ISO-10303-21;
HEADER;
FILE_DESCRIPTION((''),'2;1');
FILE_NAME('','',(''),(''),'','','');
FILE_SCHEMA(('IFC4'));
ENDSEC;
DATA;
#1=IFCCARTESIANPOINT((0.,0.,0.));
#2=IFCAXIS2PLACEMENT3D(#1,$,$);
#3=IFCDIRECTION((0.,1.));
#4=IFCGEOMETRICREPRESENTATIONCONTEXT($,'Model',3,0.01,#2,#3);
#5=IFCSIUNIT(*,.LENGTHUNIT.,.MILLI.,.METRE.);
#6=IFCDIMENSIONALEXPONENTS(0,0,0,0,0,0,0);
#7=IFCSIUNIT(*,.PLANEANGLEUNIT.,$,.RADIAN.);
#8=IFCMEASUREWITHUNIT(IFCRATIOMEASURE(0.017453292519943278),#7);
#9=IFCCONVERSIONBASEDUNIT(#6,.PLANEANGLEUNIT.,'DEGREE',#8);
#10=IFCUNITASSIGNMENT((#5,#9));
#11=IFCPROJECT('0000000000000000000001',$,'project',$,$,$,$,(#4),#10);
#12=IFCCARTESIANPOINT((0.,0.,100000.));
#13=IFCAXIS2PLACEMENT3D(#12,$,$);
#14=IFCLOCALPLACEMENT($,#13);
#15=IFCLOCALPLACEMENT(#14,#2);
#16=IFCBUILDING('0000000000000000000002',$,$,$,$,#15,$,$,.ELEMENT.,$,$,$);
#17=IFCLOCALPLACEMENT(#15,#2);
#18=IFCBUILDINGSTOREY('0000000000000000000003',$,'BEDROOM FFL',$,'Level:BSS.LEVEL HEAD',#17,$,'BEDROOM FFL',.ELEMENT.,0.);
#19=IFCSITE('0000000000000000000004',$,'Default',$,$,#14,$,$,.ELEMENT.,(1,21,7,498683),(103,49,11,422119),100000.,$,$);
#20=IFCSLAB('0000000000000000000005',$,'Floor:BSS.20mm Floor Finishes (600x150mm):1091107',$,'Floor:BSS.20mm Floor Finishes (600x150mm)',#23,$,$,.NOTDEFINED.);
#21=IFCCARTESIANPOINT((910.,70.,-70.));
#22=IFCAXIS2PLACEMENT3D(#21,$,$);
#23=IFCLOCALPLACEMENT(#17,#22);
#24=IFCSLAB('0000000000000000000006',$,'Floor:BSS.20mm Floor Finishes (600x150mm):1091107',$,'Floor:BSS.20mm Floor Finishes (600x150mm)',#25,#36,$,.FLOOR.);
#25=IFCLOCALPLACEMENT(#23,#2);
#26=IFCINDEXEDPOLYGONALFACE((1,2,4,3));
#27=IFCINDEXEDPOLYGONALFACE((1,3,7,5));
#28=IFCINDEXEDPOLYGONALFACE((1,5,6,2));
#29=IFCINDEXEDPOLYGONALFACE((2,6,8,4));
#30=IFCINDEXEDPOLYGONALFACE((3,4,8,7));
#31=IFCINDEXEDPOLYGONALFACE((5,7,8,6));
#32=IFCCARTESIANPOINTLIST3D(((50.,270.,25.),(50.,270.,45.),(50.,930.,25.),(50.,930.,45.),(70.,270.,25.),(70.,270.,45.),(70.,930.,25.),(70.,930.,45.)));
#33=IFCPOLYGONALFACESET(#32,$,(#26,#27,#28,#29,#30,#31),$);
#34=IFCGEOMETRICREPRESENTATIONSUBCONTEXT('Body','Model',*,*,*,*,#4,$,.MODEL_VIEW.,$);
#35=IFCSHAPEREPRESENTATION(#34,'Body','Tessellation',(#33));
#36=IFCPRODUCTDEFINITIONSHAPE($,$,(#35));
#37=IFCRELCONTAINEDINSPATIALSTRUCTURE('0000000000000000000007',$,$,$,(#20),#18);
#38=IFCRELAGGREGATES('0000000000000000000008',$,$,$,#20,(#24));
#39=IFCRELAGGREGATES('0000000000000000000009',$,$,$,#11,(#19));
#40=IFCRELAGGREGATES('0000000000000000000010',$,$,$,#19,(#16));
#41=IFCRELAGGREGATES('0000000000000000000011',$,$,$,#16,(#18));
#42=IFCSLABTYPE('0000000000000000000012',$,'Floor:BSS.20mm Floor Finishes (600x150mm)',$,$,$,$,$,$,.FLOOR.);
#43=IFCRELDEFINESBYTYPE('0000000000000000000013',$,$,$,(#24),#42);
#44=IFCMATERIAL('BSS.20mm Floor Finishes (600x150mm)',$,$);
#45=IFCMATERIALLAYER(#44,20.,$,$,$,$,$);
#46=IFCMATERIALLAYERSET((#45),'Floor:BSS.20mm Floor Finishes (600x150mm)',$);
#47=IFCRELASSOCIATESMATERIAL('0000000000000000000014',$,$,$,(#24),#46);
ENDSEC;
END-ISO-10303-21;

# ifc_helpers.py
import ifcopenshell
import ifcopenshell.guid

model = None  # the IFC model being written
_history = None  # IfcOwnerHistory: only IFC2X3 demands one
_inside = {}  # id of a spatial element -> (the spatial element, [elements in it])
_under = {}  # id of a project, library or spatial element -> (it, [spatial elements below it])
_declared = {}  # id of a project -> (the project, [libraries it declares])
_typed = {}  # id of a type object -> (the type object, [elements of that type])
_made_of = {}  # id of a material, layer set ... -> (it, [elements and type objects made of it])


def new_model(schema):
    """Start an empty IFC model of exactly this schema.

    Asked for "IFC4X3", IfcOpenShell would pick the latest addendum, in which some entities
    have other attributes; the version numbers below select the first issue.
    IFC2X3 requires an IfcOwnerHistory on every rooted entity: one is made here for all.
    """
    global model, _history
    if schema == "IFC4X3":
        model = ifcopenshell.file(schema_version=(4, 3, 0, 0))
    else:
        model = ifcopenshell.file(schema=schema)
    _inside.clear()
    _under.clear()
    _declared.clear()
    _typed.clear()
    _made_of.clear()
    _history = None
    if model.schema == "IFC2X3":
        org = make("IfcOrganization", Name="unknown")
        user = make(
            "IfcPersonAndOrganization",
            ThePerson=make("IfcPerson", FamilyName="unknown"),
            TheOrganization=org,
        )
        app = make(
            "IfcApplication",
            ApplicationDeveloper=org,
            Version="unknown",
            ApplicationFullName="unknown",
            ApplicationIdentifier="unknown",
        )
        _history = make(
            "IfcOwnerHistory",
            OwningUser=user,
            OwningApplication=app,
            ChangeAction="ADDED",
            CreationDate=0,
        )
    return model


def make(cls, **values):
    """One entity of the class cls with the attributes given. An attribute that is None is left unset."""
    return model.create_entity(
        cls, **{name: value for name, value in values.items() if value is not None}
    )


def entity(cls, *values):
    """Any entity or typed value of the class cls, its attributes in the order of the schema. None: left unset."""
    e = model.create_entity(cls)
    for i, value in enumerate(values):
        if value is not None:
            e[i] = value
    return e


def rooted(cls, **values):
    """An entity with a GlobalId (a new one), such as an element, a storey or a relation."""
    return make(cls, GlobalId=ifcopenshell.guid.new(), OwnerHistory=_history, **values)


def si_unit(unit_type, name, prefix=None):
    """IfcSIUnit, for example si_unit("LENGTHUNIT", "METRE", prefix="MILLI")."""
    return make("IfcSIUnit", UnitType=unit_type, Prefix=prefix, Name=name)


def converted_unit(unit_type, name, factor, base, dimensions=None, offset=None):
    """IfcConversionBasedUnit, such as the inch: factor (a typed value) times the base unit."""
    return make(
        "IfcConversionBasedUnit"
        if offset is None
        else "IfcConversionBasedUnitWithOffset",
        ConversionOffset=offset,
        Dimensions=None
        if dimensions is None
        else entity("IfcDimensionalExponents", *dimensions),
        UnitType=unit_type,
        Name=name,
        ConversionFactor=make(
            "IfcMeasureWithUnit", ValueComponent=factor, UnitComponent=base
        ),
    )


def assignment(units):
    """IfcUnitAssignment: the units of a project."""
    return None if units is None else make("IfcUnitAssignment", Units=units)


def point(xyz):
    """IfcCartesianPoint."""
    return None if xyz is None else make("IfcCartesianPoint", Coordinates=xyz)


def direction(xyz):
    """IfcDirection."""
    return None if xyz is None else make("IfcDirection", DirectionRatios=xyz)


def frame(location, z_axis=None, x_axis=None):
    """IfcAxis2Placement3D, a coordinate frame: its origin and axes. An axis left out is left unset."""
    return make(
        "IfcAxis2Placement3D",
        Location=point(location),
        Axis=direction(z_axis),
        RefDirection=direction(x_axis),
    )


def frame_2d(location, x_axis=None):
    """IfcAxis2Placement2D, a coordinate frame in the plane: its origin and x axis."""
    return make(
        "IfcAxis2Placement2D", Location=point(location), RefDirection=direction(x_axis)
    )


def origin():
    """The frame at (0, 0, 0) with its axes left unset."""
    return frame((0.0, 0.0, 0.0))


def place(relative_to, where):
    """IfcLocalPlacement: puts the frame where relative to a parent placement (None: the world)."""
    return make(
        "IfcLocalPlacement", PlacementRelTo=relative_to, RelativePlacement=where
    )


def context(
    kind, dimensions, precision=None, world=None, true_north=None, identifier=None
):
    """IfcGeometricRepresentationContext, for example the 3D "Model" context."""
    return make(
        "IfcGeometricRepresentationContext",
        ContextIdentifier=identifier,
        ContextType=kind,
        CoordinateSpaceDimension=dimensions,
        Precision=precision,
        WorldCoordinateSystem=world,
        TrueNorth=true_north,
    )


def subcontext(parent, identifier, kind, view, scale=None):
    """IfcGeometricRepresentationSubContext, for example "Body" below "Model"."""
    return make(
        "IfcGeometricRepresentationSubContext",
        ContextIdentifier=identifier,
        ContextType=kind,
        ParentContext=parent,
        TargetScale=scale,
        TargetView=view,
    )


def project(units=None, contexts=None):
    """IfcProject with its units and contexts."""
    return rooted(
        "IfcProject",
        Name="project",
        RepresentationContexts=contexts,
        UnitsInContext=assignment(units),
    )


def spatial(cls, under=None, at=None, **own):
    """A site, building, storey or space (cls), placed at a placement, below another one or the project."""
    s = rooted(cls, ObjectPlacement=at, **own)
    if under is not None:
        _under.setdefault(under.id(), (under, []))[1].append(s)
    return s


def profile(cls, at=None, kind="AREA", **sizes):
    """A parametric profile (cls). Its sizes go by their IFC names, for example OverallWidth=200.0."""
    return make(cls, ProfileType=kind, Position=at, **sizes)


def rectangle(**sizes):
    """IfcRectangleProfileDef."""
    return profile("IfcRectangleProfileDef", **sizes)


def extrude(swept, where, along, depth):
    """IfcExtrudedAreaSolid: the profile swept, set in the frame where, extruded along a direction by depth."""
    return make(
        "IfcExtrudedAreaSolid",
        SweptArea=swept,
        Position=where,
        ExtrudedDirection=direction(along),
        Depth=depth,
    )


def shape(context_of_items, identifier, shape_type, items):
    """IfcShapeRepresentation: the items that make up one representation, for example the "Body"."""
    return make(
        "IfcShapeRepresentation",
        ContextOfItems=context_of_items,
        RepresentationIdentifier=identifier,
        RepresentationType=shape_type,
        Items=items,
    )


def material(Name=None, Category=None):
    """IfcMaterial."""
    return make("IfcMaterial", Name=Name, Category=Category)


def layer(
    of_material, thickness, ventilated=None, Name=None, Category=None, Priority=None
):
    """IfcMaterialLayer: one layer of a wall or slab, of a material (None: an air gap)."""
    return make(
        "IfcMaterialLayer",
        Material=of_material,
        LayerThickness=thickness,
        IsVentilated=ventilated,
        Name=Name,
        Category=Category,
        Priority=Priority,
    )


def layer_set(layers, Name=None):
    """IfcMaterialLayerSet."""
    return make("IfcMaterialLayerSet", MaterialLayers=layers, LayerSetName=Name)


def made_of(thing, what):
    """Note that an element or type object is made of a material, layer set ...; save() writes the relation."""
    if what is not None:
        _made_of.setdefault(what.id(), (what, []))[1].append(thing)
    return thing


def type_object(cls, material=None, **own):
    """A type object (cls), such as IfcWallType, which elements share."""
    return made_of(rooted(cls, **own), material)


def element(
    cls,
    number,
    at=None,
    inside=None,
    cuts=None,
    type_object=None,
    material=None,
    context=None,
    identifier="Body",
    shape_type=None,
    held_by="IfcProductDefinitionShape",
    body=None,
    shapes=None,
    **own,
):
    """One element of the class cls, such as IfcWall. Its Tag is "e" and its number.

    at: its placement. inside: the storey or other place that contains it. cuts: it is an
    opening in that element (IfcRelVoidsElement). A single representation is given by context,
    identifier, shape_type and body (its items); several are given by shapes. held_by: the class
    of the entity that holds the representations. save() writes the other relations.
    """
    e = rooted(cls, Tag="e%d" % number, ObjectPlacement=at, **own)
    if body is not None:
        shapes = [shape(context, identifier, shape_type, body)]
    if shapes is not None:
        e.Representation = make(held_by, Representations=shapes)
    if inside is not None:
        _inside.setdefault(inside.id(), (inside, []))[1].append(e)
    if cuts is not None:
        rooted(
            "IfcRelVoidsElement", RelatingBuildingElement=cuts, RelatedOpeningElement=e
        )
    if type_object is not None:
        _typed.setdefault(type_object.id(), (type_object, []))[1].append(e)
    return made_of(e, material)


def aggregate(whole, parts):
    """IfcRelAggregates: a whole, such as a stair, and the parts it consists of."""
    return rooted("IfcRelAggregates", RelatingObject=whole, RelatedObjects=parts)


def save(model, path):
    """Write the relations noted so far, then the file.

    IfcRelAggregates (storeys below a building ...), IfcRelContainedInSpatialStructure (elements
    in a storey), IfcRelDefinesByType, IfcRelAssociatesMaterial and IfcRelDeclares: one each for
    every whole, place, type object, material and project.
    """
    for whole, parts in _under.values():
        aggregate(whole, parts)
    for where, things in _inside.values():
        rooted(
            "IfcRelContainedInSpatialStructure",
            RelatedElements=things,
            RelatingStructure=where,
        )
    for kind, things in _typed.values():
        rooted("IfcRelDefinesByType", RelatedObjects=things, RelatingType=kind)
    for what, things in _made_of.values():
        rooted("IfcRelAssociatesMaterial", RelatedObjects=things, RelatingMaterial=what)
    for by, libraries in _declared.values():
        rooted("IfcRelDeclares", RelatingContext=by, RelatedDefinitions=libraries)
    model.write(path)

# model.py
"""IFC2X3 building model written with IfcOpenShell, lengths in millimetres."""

from ifc_helpers import new_model, entity, si_unit, converted_unit, direction, frame, frame_2d, origin, place, context, subcontext, project, spatial, rectangle, extrude, material, layer, layer_set, type_object, element, aggregate, save


model = new_model("IFC2X3")

# Units and contexts
model_context = context("Model", 3, precision=0.01, world=origin(), true_north=direction((0.0, 1.0)))
body_context = subcontext(model_context, "Body", "Model", "MODEL_VIEW")
ifc_project = project(units=[si_unit("LENGTHUNIT", "METRE", prefix="MILLI"), converted_unit("PLANEANGLEUNIT", "DEGREE", entity("IfcRatioMeasure", 0.017453292519943278), si_unit("PLANEANGLEUNIT", "RADIAN"), dimensions=[0, 0, 0, 0, 0, 0, 0])], contexts=[model_context])

# Site, building, storey
site_placement = place(None, frame((0.0, 0.0, 100000.0)))
site = spatial("IfcSite", under=ifc_project, at=site_placement, Name="Default", CompositionType="ELEMENT", RefLatitude=(1, 21, 7, 498683), RefLongitude=(103, 49, 11, 422119), RefElevation=100000.0)
building_placement = place(site_placement, origin())
building = spatial("IfcBuilding", under=site, at=building_placement, CompositionType="ELEMENT")
storey_placement = place(building_placement, origin())
storey = spatial("IfcBuildingStorey", under=building, at=storey_placement, Name="BEDROOM FFL", ObjectType="Level:BSS.LEVEL HEAD", LongName="BEDROOM FFL", CompositionType="ELEMENT", Elevation=0.0)

# Slabs
slab_1_placement = place(storey_placement, frame((910.0, 70.0, -70.0)))
slab_1 = element("IfcSlab", 1, at=slab_1_placement, inside=storey, Name="Floor:BSS.20mm Floor Finishes (600x150mm):1091107", ObjectType="Floor:BSS.20mm Floor Finishes (600x150mm)", PredefinedType="NOTDEFINED")
ifc_material_1 = material(Name="BSS.20mm Floor Finishes (600x150mm)")
ifc_layer_1 = layer(ifc_material_1, 20.0)
ifc_layer_set_1 = layer_set([ifc_layer_1], Name="Floor:BSS.20mm Floor Finishes (600x150mm)")
slab_type_1 = type_object("IfcSlabType", Name="Floor:BSS.20mm Floor Finishes (600x150mm)", PredefinedType="FLOOR")
slab_2_placement = place(slab_1_placement, origin())
slab_2 = element("IfcSlab", 2, at=slab_2_placement, type_object=slab_type_1, material=ifc_layer_set_1, Name="Floor:BSS.20mm Floor Finishes (600x150mm):1091107", ObjectType="Floor:BSS.20mm Floor Finishes (600x150mm)", PredefinedType="FLOOR", context=body_context, shape_type="SweptSolid", body=[
    extrude(rectangle(XDim=660.0, YDim=20.0, at=frame_2d((0.0, 0.0), x_axis=(0.0, -1.0))), frame((60.0, 600.0, 45.0)), (0.0, 0.0, -1.0), 20.0),
])
aggregate(slab_1, [slab_2])

save(model, "model.ifc")
